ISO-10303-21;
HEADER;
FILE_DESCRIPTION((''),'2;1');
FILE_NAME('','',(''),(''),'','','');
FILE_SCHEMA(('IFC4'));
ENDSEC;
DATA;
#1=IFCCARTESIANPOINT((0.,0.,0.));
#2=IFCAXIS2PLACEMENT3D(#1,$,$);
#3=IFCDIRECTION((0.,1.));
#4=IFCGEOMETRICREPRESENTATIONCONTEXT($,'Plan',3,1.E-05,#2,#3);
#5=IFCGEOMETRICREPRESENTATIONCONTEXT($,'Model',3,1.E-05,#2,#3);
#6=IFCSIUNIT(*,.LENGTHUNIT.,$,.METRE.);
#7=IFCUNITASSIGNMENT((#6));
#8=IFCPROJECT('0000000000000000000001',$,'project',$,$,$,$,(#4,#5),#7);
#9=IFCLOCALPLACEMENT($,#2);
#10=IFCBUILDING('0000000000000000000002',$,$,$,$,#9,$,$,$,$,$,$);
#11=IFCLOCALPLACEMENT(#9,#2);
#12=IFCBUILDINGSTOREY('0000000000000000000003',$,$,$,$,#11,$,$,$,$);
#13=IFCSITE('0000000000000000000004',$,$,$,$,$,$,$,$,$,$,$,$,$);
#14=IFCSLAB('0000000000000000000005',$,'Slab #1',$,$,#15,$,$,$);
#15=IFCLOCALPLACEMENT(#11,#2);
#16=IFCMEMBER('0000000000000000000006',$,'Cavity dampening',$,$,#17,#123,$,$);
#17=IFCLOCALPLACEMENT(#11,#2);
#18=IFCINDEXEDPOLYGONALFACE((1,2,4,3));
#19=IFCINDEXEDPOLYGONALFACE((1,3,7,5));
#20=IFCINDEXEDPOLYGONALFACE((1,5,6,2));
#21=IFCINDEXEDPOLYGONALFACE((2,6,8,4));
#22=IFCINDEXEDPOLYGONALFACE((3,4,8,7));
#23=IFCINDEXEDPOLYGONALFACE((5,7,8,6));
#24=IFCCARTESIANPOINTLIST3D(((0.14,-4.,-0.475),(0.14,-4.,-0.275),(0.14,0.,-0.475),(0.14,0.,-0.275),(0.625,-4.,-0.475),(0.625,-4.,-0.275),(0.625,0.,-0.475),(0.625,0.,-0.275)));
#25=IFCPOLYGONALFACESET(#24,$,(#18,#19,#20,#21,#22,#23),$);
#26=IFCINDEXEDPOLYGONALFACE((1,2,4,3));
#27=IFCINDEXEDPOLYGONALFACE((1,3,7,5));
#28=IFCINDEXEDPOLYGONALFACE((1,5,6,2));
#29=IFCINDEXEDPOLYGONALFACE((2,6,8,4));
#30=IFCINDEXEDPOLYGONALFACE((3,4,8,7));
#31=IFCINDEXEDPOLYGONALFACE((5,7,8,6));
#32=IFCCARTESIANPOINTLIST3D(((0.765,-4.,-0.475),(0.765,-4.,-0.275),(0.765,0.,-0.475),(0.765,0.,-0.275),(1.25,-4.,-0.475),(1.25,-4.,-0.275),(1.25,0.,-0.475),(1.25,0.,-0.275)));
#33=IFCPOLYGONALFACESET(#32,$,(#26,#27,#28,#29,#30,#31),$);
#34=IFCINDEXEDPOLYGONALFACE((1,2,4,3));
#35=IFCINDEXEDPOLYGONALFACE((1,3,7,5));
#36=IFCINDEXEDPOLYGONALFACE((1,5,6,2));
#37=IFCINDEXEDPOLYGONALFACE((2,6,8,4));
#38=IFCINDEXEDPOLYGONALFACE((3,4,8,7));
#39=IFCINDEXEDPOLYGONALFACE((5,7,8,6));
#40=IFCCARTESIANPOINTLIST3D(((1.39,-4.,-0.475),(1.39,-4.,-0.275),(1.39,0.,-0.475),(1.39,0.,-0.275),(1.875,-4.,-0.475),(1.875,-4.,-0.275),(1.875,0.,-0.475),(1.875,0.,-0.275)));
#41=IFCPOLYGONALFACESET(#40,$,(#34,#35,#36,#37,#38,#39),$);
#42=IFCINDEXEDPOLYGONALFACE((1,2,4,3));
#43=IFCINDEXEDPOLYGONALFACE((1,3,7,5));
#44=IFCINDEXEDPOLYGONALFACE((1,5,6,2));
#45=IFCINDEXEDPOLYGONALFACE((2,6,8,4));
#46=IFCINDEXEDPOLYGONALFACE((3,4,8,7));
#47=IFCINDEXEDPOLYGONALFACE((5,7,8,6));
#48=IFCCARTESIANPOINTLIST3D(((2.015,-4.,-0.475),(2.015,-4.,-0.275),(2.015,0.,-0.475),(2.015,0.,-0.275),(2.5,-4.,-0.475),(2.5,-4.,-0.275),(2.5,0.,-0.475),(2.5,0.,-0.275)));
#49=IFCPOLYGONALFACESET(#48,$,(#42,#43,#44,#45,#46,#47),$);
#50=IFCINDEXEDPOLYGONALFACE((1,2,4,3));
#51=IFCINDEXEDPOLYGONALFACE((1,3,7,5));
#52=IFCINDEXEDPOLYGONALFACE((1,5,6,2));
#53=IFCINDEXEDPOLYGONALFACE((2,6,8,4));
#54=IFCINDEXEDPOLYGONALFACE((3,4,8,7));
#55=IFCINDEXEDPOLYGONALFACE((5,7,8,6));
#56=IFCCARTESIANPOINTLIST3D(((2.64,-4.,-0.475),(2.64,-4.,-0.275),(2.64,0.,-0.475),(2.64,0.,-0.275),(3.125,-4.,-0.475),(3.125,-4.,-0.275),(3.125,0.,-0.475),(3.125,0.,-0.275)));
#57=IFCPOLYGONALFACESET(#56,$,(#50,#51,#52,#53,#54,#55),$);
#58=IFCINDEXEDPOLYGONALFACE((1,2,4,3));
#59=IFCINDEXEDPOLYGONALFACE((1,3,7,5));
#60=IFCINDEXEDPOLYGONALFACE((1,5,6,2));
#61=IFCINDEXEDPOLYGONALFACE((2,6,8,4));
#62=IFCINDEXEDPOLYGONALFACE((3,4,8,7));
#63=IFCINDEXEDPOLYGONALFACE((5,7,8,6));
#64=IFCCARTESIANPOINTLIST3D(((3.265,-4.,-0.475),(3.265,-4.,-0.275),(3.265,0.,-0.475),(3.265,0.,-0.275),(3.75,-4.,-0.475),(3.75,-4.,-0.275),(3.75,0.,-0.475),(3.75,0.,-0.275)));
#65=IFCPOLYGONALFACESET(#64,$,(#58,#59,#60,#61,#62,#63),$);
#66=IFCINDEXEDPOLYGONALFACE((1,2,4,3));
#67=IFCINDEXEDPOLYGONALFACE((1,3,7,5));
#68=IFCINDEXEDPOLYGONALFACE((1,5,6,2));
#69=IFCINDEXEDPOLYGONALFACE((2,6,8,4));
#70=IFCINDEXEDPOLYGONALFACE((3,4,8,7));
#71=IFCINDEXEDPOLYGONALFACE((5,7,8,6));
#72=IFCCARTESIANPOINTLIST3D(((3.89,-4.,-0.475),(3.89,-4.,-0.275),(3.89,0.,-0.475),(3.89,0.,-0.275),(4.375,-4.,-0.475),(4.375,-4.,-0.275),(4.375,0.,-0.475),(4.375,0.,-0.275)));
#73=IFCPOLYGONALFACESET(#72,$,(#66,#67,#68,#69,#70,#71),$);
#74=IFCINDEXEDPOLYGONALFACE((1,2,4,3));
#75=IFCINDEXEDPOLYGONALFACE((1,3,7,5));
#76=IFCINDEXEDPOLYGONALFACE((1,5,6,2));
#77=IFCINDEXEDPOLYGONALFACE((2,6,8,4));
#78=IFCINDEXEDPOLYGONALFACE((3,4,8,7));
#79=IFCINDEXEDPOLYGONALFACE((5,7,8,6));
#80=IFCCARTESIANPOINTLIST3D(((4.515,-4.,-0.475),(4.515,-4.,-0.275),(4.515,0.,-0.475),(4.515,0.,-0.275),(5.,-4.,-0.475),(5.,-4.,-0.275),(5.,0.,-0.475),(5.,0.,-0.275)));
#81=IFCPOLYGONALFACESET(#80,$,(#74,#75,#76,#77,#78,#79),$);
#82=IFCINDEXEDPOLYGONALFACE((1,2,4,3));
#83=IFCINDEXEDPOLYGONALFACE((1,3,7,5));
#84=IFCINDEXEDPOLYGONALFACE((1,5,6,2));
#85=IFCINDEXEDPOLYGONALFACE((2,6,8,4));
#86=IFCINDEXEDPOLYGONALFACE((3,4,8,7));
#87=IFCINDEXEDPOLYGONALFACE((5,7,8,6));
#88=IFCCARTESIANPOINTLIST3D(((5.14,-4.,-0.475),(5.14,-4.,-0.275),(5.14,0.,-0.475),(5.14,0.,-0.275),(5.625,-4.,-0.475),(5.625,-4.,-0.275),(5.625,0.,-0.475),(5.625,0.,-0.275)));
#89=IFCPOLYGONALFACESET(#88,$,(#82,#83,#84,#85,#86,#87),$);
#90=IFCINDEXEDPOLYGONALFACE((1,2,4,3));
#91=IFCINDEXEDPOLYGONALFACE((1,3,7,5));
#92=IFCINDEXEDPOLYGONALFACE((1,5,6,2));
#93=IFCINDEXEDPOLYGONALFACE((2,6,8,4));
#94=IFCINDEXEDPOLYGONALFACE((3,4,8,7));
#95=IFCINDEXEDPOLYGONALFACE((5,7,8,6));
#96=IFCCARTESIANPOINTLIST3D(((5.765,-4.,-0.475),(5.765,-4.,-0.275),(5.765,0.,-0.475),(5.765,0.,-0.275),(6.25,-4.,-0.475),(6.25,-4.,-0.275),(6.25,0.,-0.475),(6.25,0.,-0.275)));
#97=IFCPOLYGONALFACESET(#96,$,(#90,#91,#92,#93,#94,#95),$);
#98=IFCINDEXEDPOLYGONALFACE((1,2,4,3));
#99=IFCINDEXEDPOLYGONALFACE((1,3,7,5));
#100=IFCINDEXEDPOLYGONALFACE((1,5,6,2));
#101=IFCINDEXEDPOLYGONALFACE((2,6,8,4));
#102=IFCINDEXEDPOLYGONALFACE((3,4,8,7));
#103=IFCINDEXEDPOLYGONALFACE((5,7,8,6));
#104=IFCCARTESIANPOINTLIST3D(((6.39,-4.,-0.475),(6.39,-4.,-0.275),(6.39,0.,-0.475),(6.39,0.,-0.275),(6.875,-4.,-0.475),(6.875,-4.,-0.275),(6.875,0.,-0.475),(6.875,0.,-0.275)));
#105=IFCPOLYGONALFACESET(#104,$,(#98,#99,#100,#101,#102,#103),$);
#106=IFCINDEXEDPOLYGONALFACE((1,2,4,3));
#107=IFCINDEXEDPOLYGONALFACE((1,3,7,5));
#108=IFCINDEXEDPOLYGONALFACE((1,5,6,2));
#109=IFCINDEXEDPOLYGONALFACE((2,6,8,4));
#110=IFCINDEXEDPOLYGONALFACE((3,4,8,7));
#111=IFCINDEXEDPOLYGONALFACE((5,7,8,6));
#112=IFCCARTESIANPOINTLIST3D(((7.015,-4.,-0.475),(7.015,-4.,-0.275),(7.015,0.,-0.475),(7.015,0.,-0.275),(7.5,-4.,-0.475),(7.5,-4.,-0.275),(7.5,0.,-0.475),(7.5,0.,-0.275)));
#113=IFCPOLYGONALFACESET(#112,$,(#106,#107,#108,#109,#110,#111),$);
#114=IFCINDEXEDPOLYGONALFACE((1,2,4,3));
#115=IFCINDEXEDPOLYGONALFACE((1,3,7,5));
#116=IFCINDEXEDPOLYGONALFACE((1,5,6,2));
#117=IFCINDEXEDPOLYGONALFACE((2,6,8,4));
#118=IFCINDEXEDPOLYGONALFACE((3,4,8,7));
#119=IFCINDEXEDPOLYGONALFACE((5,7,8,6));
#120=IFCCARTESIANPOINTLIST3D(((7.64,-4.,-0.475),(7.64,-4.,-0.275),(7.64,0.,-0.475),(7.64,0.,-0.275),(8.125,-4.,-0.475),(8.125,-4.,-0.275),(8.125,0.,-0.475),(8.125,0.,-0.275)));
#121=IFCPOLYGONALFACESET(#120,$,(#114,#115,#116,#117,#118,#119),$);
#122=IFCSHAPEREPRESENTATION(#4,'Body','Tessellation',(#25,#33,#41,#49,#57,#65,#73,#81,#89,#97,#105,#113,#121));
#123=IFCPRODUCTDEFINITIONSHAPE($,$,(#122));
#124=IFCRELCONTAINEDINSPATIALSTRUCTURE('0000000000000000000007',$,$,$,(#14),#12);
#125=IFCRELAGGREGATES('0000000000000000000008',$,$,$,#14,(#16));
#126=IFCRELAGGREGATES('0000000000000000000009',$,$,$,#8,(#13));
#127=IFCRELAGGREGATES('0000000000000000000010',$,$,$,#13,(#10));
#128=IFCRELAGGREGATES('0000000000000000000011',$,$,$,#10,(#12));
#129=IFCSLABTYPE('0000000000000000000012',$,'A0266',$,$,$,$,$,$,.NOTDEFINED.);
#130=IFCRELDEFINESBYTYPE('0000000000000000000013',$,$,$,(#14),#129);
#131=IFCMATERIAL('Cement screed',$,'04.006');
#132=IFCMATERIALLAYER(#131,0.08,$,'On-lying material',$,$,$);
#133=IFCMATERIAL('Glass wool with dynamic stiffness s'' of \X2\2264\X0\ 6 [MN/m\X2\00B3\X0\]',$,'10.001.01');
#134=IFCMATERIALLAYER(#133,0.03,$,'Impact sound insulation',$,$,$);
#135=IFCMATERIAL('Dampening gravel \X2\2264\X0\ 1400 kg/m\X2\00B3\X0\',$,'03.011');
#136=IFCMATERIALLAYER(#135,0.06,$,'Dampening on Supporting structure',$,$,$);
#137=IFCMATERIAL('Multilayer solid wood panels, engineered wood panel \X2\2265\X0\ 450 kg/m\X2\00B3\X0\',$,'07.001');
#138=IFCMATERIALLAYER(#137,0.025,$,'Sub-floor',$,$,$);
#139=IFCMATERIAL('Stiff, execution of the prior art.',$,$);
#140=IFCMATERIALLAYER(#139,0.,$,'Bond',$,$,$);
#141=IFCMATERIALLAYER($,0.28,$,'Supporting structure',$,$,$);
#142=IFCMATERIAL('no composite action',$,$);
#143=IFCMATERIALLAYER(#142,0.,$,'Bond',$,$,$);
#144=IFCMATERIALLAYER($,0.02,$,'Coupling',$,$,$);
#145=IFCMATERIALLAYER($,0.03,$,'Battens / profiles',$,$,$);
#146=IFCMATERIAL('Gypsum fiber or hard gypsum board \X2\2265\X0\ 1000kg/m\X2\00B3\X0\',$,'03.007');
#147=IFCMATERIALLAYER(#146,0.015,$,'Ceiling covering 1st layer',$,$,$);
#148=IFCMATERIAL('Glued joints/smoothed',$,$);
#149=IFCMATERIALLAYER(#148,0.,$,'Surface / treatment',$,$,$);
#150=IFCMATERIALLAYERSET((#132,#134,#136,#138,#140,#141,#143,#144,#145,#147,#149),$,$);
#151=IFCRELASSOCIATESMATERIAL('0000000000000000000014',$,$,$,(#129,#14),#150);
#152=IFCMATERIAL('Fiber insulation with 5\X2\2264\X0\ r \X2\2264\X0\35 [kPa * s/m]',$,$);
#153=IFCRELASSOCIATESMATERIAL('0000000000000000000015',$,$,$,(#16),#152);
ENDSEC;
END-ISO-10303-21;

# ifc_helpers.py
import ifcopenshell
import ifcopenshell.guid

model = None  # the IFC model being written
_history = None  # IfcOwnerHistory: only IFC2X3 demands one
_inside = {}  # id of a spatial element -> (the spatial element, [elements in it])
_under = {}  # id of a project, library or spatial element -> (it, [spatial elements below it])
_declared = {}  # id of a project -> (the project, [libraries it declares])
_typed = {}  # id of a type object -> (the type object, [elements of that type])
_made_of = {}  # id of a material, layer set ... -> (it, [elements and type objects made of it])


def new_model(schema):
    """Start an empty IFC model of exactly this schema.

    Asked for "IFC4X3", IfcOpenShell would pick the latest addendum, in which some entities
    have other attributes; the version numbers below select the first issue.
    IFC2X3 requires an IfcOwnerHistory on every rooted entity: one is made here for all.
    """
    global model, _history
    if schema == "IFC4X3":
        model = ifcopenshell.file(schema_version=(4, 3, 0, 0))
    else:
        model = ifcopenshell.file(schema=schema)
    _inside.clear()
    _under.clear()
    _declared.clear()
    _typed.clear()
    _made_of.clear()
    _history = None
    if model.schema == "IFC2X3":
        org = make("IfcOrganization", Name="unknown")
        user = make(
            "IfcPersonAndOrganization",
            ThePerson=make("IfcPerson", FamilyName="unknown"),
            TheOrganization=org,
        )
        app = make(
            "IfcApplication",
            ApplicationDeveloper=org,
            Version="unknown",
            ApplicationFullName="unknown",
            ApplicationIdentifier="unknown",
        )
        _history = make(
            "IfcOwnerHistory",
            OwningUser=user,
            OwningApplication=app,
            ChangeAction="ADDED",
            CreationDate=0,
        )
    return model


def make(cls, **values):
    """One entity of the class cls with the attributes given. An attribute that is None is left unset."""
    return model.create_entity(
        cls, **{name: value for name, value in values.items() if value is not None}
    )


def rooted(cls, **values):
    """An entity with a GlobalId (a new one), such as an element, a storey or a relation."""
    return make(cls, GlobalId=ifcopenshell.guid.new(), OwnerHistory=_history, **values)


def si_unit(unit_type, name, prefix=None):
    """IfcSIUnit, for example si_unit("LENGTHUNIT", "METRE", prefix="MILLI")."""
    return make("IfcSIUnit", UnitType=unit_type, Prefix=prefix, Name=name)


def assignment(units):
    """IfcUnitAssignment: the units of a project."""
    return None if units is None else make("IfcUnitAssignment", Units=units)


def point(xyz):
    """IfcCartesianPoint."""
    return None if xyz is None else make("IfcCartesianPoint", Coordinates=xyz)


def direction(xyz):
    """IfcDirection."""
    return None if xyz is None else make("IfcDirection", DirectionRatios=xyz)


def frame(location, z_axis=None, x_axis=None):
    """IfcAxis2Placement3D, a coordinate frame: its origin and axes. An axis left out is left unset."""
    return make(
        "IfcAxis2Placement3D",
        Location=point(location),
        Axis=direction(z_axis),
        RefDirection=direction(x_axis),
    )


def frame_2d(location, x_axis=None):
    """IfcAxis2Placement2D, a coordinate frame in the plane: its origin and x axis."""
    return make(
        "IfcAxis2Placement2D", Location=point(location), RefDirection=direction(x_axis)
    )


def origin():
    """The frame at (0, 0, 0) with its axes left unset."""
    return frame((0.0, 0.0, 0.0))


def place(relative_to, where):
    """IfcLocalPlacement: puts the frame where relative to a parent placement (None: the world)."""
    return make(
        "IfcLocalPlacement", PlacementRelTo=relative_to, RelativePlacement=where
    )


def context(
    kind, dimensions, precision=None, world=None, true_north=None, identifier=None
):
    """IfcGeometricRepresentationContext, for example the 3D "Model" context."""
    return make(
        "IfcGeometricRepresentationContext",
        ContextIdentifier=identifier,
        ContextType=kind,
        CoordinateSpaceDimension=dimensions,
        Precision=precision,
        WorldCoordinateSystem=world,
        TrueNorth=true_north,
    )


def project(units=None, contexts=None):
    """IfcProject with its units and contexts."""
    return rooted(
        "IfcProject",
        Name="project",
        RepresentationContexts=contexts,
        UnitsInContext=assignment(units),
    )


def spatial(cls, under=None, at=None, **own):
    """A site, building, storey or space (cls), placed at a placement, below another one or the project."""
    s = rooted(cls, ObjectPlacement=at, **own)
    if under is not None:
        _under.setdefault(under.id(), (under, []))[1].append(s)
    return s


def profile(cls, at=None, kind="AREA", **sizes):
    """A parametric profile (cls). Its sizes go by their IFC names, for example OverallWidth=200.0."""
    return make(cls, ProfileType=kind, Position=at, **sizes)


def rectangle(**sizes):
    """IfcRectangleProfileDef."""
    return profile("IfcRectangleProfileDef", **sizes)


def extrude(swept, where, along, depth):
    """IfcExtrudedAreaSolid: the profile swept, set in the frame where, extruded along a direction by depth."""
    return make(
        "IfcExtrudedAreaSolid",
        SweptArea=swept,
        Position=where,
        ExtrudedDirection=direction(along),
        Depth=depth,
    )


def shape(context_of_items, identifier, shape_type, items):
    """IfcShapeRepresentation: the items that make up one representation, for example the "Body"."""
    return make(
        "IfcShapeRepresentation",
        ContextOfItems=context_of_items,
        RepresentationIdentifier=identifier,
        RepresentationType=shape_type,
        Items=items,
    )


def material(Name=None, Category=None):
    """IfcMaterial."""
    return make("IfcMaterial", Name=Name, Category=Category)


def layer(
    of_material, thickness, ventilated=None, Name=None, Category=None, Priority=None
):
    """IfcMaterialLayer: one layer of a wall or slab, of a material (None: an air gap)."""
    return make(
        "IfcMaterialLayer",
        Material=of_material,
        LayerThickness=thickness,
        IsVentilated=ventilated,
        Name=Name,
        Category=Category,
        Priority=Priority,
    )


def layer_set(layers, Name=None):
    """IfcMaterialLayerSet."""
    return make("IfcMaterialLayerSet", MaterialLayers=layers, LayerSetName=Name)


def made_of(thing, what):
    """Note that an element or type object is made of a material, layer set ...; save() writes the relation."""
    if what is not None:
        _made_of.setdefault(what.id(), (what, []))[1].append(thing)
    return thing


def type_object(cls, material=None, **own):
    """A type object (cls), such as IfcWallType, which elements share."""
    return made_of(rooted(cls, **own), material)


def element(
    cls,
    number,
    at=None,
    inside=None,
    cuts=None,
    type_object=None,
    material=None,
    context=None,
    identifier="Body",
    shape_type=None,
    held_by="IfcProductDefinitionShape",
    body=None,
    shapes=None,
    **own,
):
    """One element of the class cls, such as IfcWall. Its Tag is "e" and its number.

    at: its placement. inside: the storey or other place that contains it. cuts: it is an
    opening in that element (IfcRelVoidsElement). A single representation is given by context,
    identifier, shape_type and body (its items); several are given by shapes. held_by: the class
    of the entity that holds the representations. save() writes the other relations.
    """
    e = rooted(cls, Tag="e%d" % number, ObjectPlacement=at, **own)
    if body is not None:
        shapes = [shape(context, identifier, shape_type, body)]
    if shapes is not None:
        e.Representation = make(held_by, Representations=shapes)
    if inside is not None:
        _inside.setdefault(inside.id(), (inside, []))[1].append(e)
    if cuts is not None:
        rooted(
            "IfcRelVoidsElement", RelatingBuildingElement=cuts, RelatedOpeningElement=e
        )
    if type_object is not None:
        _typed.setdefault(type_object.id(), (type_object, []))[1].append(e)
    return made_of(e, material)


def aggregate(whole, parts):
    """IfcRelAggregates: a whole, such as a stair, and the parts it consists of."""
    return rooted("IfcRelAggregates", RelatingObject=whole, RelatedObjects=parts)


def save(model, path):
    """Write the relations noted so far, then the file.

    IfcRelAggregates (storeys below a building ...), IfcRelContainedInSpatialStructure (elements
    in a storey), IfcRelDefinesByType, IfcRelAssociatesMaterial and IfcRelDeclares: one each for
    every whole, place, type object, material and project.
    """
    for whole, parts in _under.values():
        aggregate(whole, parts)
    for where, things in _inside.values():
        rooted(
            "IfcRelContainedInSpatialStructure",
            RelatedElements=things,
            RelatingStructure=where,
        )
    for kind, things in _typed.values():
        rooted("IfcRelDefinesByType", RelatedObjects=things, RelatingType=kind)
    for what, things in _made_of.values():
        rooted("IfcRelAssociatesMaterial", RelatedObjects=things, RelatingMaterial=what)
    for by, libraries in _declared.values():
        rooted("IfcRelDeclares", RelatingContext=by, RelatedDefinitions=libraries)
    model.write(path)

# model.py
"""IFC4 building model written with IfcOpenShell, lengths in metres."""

from ifc_helpers import new_model, si_unit, direction, frame, frame_2d, origin, place, context, project, spatial, rectangle, extrude, material, layer, layer_set, type_object, element, aggregate, save


model = new_model("IFC4")

# Units and contexts
plan_context = context("Plan", 3, precision=1e-05, world=origin(), true_north=direction((0.0, 1.0)))
model_context = context("Model", 3, precision=1e-05, world=origin(), true_north=direction((0.0, 1.0)))
ifc_project = project(units=[si_unit("LENGTHUNIT", "METRE")], contexts=[plan_context, model_context])

# Site, building, storey
site = spatial("IfcSite", under=ifc_project)
building_placement = place(None, origin())
building = spatial("IfcBuilding", under=site, at=building_placement)
storey_placement = place(building_placement, origin())
storey = spatial("IfcBuildingStorey", under=building, at=storey_placement)

# Slab, member
ifc_material_1 = material(Name="Cement screed", Category="04.006")
ifc_layer_1 = layer(ifc_material_1, 0.08, Name="On-lying material")
ifc_material_2 = material(Name="Glass wool with dynamic stiffness s' of ≤ 6 [MN/m³]", Category="10.001.01")
ifc_layer_2 = layer(ifc_material_2, 0.03, Name="Impact sound insulation")
ifc_material_3 = material(Name="Dampening gravel ≤ 1400 kg/m³", Category="03.011")
ifc_layer_3 = layer(ifc_material_3, 0.06, Name="Dampening on Supporting structure")
ifc_material_4 = material(Name="Multilayer solid wood panels, engineered wood panel ≥ 450 kg/m³", Category="07.001")
ifc_layer_4 = layer(ifc_material_4, 0.025, Name="Sub-floor")
ifc_material_5 = material(Name="Stiff, execution of the prior art.")
ifc_layer_5 = layer(ifc_material_5, 0.0, Name="Bond")
ifc_layer_6 = layer(None, 0.28, Name="Supporting structure")
ifc_material_6 = material(Name="no composite action")
ifc_layer_7 = layer(ifc_material_6, 0.0, Name="Bond")
ifc_layer_8 = layer(None, 0.02, Name="Coupling")
ifc_layer_9 = layer(None, 0.03, Name="Battens / profiles")
ifc_material_7 = material(Name="Gypsum fiber or hard gypsum board ≥ 1000kg/m³", Category="03.007")
ifc_layer_10 = layer(ifc_material_7, 0.015, Name="Ceiling covering 1st layer")
ifc_material_8 = material(Name="Glued joints/smoothed")
ifc_layer_11 = layer(ifc_material_8, 0.0, Name="Surface / treatment")
ifc_layer_set = layer_set([ifc_layer_1, ifc_layer_2, ifc_layer_3, ifc_layer_4, ifc_layer_5, ifc_layer_6, ifc_layer_7, ifc_layer_8, ifc_layer_9, ifc_layer_10, ifc_layer_11])
slab_type = type_object("IfcSlabType", Name="A0266", PredefinedType="NOTDEFINED", material=ifc_layer_set)
slab_placement = place(None, frame((0.0, 0.0, 0.0), z_axis=(0.0, 0.0, -1.0), x_axis=(1.0, 0.0, 0.0)))
slab = element("IfcSlab", 1, at=slab_placement, inside=storey, type_object=slab_type, material=ifc_layer_set, Name="Slab #1")
ifc_material_9 = material(Name="Fiber insulation with 5≤ r ≤35 [kPa * s/m]")
member_1_placement = place(slab_placement, origin())
member_1 = element("IfcMember", 2, at=member_1_placement, material=ifc_material_9, Name="Cavity dampening", context=plan_context, shape_type="SweptSolid", body=[
    extrude(rectangle(XDim=0.485, YDim=0.2, at=frame_2d((0.2425, 0.1), x_axis=(1.0, 0.0))), frame((0.14, 4.0, 0.275), z_axis=(0.0, -1.0, 0.0), x_axis=(1.0, 0.0, 0.0)), (0.0, 0.0, 1.0), 4.0),
    extrude(rectangle(XDim=0.485, YDim=0.2, at=frame_2d((0.2425, 0.1), x_axis=(1.0, 0.0))), frame((0.765, 4.0, 0.275), z_axis=(0.0, -1.0, 0.0), x_axis=(1.0, 0.0, 0.0)), (0.0, 0.0, 1.0), 4.0),
    extrude(rectangle(XDim=0.485, YDim=0.2, at=frame_2d((0.2425, 0.1), x_axis=(1.0, 0.0))), frame((1.39, 4.0, 0.275), z_axis=(0.0, -1.0, 0.0), x_axis=(1.0, 0.0, 0.0)), (0.0, 0.0, 1.0), 4.0),
    extrude(rectangle(XDim=0.485, YDim=0.2, at=frame_2d((0.2425, 0.1), x_axis=(1.0, 0.0))), frame((2.015, 4.0, 0.275), z_axis=(0.0, -1.0, 0.0), x_axis=(1.0, 0.0, 0.0)), (0.0, 0.0, 1.0), 4.0),
    extrude(rectangle(XDim=0.485, YDim=0.2, at=frame_2d((0.2425, 0.1), x_axis=(1.0, 0.0))), frame((2.64, 4.0, 0.275), z_axis=(0.0, -1.0, 0.0), x_axis=(1.0, 0.0, 0.0)), (0.0, 0.0, 1.0), 4.0),
    extrude(rectangle(XDim=0.485, YDim=0.2, at=frame_2d((0.2425, 0.1), x_axis=(1.0, 0.0))), frame((3.265, 4.0, 0.275), z_axis=(0.0, -1.0, 0.0), x_axis=(1.0, 0.0, 0.0)), (0.0, 0.0, 1.0), 4.0),
    extrude(rectangle(XDim=0.485, YDim=0.2, at=frame_2d((0.2425, 0.1), x_axis=(1.0, 0.0))), frame((3.89, 4.0, 0.275), z_axis=(0.0, -1.0, 0.0), x_axis=(1.0, 0.0, 0.0)), (0.0, 0.0, 1.0), 4.0),
    extrude(rectangle(XDim=0.485, YDim=0.2, at=frame_2d((0.2425, 0.1), x_axis=(1.0, 0.0))), frame((4.515, 4.0, 0.275), z_axis=(0.0, -1.0, 0.0), x_axis=(1.0, 0.0, 0.0)), (0.0, 0.0, 1.0), 4.0),
    extrude(rectangle(XDim=0.485, YDim=0.2, at=frame_2d((0.2425, 0.1), x_axis=(1.0, 0.0))), frame((5.14, 4.0, 0.275), z_axis=(0.0, -1.0, 0.0), x_axis=(1.0, 0.0, 0.0)), (0.0, 0.0, 1.0), 4.0),
    extrude(rectangle(XDim=0.485, YDim=0.2, at=frame_2d((0.2425, 0.1), x_axis=(1.0, 0.0))), frame((5.765, 4.0, 0.275), z_axis=(0.0, -1.0, 0.0), x_axis=(1.0, 0.0, 0.0)), (0.0, 0.0, 1.0), 4.0),
    extrude(rectangle(XDim=0.485, YDim=0.2, at=frame_2d((0.2425, 0.1), x_axis=(1.0, 0.0))), frame((6.39, 4.0, 0.275), z_axis=(0.0, -1.0, 0.0), x_axis=(1.0, 0.0, 0.0)), (0.0, 0.0, 1.0), 4.0),
    extrude(rectangle(XDim=0.485, YDim=0.2, at=frame_2d((0.2425, 0.1), x_axis=(1.0, 0.0))), frame((7.015, 4.0, 0.275), z_axis=(0.0, -1.0, 0.0), x_axis=(1.0, 0.0, 0.0)), (0.0, 0.0, 1.0), 4.0),
    extrude(rectangle(XDim=0.485, YDim=0.2, at=frame_2d((0.2425, 0.1), x_axis=(1.0, 0.0))), frame((7.64, 4.0, 0.275), z_axis=(0.0, -1.0, 0.0), x_axis=(1.0, 0.0, 0.0)), (0.0, 0.0, 1.0), 4.0),
])
aggregate(slab, [member_1])

save(model, "model.ifc")
